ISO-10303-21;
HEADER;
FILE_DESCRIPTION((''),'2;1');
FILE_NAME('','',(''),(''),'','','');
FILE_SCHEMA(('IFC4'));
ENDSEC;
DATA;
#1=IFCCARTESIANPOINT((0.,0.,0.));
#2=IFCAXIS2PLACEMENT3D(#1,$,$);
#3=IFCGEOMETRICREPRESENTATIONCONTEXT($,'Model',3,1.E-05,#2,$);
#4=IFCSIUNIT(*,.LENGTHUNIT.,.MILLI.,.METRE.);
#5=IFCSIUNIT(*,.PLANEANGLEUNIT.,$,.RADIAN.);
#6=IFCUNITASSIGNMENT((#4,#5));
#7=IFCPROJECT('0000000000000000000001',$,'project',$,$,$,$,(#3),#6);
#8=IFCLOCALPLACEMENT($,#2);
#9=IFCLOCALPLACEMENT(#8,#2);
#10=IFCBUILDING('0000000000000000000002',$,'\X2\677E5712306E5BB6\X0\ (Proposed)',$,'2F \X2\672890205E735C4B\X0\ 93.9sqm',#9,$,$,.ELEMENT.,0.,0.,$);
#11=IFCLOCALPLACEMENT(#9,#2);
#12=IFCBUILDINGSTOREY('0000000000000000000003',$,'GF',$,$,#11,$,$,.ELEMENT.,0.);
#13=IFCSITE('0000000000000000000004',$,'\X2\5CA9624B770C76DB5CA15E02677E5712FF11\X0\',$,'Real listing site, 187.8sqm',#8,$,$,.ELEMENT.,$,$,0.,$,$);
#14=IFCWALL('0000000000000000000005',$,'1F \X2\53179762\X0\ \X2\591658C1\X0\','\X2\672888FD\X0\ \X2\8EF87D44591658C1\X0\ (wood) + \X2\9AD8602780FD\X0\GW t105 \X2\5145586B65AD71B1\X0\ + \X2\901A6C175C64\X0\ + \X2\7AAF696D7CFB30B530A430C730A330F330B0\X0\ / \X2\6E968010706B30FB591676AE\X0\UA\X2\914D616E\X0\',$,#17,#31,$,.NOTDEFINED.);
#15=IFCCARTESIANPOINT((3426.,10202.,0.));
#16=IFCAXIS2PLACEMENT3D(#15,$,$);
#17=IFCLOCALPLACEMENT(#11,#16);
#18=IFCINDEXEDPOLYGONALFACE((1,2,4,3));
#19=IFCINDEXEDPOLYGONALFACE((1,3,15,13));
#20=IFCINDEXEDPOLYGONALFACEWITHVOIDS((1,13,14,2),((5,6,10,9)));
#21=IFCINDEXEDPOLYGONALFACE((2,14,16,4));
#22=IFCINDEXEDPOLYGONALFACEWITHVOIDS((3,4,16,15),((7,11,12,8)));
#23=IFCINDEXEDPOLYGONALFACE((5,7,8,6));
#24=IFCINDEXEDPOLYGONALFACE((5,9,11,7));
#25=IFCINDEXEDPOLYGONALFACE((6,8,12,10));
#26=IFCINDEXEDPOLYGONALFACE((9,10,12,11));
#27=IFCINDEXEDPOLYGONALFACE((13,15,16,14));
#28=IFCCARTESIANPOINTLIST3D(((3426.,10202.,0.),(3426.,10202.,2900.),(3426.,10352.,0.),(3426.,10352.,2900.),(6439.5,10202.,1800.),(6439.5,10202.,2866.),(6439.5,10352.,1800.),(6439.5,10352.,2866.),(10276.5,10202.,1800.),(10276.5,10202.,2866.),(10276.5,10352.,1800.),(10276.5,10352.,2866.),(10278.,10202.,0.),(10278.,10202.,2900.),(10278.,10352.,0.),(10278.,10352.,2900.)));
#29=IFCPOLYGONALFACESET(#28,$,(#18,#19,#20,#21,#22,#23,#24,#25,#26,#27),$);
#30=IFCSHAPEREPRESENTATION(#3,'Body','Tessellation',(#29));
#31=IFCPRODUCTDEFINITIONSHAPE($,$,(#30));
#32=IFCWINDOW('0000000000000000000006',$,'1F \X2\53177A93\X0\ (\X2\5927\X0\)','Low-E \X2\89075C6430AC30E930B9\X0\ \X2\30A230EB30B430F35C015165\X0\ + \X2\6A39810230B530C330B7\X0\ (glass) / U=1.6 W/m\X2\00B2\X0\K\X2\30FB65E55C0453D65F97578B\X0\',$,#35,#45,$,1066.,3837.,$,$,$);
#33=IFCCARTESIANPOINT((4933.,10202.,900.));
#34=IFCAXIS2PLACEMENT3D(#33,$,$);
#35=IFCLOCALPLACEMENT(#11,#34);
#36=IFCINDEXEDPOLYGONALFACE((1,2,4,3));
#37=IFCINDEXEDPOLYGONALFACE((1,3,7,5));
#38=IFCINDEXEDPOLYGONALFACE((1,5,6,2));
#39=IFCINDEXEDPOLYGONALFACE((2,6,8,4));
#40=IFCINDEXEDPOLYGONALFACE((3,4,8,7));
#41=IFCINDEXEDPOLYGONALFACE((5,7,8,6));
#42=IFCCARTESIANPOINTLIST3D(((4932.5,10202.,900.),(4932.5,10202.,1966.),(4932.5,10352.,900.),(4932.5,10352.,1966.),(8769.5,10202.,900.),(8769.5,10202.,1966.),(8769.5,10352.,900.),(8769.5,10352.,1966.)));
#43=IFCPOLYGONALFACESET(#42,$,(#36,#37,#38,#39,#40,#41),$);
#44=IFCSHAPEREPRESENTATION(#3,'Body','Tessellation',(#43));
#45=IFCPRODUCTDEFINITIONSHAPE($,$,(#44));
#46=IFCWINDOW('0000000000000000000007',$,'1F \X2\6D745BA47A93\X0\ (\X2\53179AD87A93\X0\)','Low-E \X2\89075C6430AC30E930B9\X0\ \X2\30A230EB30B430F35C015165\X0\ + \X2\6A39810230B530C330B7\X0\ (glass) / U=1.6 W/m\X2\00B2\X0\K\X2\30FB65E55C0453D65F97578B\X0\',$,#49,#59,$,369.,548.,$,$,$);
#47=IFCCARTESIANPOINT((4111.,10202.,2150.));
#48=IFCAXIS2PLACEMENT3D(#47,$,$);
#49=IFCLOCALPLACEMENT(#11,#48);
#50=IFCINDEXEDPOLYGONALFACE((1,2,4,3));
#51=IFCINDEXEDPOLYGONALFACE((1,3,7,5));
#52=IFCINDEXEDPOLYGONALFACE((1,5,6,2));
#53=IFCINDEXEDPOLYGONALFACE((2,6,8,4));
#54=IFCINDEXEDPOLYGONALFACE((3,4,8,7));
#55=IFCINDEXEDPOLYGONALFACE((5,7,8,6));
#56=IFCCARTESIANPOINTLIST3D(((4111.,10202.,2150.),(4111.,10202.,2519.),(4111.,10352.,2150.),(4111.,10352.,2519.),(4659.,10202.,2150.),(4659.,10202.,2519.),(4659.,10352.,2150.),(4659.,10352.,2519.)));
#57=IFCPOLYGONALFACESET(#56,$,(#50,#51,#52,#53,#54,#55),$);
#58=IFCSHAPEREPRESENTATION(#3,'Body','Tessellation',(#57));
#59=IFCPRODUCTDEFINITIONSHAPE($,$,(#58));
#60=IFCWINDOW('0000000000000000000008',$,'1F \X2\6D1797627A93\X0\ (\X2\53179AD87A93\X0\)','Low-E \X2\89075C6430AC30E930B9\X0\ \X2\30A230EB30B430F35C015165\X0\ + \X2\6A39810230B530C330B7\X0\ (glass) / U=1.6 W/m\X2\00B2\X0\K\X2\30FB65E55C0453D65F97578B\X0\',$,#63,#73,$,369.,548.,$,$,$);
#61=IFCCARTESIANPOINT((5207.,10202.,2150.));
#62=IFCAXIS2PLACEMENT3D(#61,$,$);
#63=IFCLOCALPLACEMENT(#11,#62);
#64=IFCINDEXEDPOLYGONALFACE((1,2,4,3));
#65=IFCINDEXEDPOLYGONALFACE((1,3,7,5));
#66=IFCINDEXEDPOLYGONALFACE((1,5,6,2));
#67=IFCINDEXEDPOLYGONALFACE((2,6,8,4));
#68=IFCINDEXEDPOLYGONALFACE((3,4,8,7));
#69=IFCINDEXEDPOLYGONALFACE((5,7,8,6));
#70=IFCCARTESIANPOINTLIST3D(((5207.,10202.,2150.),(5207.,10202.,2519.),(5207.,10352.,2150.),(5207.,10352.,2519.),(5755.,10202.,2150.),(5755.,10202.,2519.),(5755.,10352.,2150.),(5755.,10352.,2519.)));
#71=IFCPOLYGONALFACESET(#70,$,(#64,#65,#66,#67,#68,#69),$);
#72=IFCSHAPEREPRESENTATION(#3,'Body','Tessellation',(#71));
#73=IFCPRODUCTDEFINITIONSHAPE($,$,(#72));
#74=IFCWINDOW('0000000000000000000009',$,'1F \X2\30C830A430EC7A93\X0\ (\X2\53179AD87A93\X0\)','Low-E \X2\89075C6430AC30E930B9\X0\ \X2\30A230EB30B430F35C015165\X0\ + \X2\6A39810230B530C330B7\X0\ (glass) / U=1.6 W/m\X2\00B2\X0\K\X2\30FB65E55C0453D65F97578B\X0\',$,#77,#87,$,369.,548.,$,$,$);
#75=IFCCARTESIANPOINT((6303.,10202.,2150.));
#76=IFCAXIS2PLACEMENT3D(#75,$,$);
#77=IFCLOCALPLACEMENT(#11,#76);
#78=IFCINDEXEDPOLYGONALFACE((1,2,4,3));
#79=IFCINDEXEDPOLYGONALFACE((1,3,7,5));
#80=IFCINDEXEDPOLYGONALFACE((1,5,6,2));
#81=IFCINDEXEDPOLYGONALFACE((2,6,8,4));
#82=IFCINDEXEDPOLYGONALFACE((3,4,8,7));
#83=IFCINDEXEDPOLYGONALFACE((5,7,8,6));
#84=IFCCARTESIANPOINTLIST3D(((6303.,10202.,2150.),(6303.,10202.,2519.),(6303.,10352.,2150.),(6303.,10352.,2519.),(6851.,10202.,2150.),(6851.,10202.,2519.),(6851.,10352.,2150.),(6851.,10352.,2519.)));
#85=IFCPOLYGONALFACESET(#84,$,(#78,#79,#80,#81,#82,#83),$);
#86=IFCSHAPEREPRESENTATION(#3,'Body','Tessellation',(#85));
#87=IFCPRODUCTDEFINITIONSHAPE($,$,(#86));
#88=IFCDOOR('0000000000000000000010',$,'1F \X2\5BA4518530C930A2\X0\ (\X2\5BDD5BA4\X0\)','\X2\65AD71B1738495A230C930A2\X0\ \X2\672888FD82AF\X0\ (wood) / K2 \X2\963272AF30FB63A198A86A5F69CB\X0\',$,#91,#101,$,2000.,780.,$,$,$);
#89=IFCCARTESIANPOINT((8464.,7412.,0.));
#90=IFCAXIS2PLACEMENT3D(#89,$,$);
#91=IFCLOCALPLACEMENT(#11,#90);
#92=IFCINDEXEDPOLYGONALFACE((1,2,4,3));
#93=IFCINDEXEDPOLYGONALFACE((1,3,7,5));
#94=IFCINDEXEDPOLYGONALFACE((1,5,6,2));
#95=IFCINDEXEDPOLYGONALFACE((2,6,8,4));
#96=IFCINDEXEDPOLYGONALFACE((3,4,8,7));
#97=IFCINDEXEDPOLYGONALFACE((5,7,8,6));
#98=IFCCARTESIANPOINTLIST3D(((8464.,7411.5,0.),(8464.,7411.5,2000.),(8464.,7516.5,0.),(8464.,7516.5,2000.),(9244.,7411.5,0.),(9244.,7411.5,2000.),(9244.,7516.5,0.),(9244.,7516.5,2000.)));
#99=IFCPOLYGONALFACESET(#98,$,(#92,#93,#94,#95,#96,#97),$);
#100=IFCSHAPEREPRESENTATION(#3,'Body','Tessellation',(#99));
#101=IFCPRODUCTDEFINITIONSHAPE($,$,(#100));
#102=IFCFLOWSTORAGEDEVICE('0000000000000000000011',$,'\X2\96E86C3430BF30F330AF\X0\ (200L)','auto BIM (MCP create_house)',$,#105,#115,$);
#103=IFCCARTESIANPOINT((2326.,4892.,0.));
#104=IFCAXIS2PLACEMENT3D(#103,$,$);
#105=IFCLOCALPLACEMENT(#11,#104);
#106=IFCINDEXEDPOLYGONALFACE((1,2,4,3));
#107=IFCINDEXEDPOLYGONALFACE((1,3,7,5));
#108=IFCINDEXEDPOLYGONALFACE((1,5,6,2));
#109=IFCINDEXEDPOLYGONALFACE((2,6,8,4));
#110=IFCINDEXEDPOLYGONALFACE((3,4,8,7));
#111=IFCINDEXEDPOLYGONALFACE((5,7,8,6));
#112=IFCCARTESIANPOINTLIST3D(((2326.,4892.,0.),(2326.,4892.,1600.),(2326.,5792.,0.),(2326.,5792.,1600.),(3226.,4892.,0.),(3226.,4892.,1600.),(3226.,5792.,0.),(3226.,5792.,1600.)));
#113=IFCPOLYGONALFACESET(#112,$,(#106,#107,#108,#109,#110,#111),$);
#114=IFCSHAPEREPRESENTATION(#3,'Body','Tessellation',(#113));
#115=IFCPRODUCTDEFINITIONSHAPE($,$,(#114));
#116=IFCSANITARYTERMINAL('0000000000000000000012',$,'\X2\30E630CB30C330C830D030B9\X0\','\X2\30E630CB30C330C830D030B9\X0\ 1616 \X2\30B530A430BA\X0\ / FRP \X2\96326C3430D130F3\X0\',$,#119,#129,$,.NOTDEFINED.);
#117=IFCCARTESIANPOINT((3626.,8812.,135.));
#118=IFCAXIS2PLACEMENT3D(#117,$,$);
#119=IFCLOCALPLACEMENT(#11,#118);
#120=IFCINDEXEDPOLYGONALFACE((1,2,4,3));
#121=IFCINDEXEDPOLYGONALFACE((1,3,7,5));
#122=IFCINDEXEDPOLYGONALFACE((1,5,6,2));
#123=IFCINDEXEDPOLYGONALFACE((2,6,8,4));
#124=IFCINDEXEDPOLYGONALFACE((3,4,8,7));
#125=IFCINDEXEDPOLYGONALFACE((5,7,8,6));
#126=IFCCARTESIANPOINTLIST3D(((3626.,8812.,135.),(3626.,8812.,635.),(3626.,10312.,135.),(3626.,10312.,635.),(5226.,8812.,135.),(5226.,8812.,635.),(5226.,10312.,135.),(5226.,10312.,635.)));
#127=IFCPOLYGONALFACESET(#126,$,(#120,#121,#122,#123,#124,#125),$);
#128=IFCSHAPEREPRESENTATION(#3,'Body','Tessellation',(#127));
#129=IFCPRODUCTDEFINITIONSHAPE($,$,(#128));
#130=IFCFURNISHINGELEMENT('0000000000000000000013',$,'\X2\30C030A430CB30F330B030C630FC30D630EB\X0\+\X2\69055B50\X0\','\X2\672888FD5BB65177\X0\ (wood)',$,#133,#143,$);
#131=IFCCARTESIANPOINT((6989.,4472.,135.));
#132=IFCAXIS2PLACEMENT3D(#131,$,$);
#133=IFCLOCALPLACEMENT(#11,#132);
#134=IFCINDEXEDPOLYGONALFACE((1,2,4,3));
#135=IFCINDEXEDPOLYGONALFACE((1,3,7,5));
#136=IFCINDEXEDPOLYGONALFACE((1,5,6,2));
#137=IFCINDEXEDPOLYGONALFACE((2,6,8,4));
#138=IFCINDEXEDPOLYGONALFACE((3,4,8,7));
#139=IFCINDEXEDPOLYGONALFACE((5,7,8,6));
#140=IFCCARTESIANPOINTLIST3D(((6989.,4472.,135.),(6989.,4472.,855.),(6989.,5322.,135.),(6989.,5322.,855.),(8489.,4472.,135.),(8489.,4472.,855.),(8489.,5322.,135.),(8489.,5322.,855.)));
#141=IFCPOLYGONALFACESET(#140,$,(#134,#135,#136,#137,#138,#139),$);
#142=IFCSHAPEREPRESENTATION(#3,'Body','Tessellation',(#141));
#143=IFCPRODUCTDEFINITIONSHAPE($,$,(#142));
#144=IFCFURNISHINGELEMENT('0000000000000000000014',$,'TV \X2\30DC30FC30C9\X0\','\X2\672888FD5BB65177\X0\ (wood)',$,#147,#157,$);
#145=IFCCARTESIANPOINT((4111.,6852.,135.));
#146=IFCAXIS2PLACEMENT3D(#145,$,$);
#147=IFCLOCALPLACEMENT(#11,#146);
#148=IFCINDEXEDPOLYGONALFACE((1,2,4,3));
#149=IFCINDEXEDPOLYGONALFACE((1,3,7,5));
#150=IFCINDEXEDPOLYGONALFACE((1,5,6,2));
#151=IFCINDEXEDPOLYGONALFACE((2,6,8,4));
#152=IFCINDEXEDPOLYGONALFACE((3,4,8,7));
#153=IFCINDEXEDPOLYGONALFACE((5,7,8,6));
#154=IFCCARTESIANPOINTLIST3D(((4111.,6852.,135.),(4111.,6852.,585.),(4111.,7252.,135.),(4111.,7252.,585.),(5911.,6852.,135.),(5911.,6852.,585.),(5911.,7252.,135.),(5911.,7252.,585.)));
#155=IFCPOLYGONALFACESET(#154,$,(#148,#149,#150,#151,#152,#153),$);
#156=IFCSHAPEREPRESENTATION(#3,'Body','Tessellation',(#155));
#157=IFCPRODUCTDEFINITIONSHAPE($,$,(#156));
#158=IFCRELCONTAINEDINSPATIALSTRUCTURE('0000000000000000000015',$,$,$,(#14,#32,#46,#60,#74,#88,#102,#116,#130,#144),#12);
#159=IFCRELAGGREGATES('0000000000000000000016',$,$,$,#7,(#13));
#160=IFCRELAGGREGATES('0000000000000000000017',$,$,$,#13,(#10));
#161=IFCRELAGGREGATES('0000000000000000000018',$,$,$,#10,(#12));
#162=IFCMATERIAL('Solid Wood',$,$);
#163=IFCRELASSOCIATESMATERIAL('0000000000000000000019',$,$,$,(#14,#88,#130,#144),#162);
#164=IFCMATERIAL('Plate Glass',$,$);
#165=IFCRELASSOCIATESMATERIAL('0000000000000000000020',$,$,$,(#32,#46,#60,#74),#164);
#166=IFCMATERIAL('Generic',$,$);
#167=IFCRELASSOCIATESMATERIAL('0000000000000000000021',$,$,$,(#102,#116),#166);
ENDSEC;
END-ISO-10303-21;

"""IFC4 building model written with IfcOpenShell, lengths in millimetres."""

from ifc_helpers import new_model, si_unit, frame, frame_2d, origin, place, context, project, spatial, rectangle, extrude, material, element, fill, save


model = new_model("IFC4")

# Units and contexts
model_context = context("Model", 3, precision=1e-05, world=origin())
ifc_project = project(units=[si_unit("LENGTHUNIT", "METRE", prefix="MILLI"), si_unit("PLANEANGLEUNIT", "RADIAN")], contexts=[model_context])

# Site, building, storey
site_placement = place(None, origin())
site = spatial("IfcSite", under=ifc_project, at=site_placement, Name="岩手県盛岡市松園１", ObjectType="Real listing site, 187.8sqm", CompositionType="ELEMENT", RefElevation=0.0)
building_placement = place(site_placement, origin())
building = spatial("IfcBuilding", under=site, at=building_placement, Name="松園の家 (Proposed)", ObjectType="2F 木造平屋 93.9sqm", CompositionType="ELEMENT", ElevationOfRefHeight=0.0, ElevationOfTerrain=0.0)
storey_placement = place(building_placement, origin())
storey = spatial("IfcBuildingStorey", under=building, at=storey_placement, Name="GF", CompositionType="ELEMENT", Elevation=0.0)

# Wall, openings, windows
ifc_material_1 = material(Name="Solid Wood")
wall_1_placement = place(storey_placement, frame((3426.0, 10202.0, 0.0)))
wall_1 = element("IfcWall", 1, at=wall_1_placement, inside=storey, material=ifc_material_1, Name="1F 北面 外壁", Description="木製 軸組外壁 (wood) + 高性能GW t105 充填断熱 + 通気層 + 窯業系サイディング / 準耐火・外皮UA配慮", PredefinedType="NOTDEFINED", context=model_context, shape_type="SweptSolid", body=[
    extrude(rectangle(XDim=6852.0, YDim=150.0, at=frame_2d((3426.0, 75.0))), frame((3426.0, 10202.0, 0.0)), (0.0, 0.0, 1.0), 2900.0),
])
opening_1_placement = place(storey_placement, frame((4933.0, 10202.0, 900.0)))
opening_1 = element("IfcOpeningElement", 2, at=opening_1_placement, cuts=wall_1, PredefinedType="NOTDEFINED", context=model_context, shape_type="SweptSolid", body=[
    extrude(rectangle(XDim=3837.0, YDim=150.0, at=frame_2d((1918.0, 75.0))), frame((4933.0, 10202.0, 900.0)), (0.0, 0.0, 1.0), 1066.0),
])
opening_2_placement = place(storey_placement, frame((4111.0, 10202.0, 2150.0)))
opening_2 = element("IfcOpeningElement", 3, at=opening_2_placement, cuts=wall_1, PredefinedType="NOTDEFINED", context=model_context, shape_type="SweptSolid", body=[
    extrude(rectangle(XDim=548.0, YDim=150.0, at=frame_2d((274.0, 75.0))), frame((4111.0, 10202.0, 2150.0)), (0.0, 0.0, 1.0), 369.0),
])
opening_3_placement = place(storey_placement, frame((5207.0, 10202.0, 2150.0)))
opening_3 = element("IfcOpeningElement", 4, at=opening_3_placement, cuts=wall_1, PredefinedType="NOTDEFINED", context=model_context, shape_type="SweptSolid", body=[
    extrude(rectangle(XDim=548.0, YDim=150.0, at=frame_2d((274.0, 75.0))), frame((5207.0, 10202.0, 2150.0)), (0.0, 0.0, 1.0), 369.0),
])
opening_4_placement = place(storey_placement, frame((6303.0, 10202.0, 2150.0)))
opening_4 = element("IfcOpeningElement", 5, at=opening_4_placement, cuts=wall_1, PredefinedType="NOTDEFINED", context=model_context, shape_type="SweptSolid", body=[
    extrude(rectangle(XDim=548.0, YDim=150.0, at=frame_2d((274.0, 75.0))), frame((6303.0, 10202.0, 2150.0)), (0.0, 0.0, 1.0), 369.0),
])
ifc_material_2 = material(Name="Plate Glass")
window_1_placement = place(storey_placement, frame((4933.0, 10202.0, 900.0)))
window_1 = element("IfcWindow", 6, at=window_1_placement, inside=storey, material=ifc_material_2, Name="1F 北窓 (大)", Description="Low-E 複層ガラス アルゴン封入 + 樹脂サッシ (glass) / U=1.6 W/m²K・日射取得型", OverallHeight=1066.0, OverallWidth=3837.0, context=model_context, shape_type="SweptSolid", body=[
    extrude(rectangle(XDim=3837.0, YDim=150.0, at=frame_2d((1918.0, 75.0))), frame((4933.0, 10202.0, 900.0)), (0.0, 0.0, 1.0), 1066.0),
])
fill(opening_1, window_1)
window_2_placement = place(storey_placement, frame((4111.0, 10202.0, 2150.0)))
window_2 = element("IfcWindow", 7, at=window_2_placement, inside=storey, material=ifc_material_2, Name="1F 浴室窓 (北高窓)", Description="Low-E 複層ガラス アルゴン封入 + 樹脂サッシ (glass) / U=1.6 W/m²K・日射取得型", OverallHeight=369.0, OverallWidth=548.0, context=model_context, shape_type="SweptSolid", body=[
    extrude(rectangle(XDim=548.0, YDim=150.0, at=frame_2d((274.0, 75.0))), frame((4111.0, 10202.0, 2150.0)), (0.0, 0.0, 1.0), 369.0),
])
fill(opening_2, window_2)
window_3_placement = place(storey_placement, frame((5207.0, 10202.0, 2150.0)))
window_3 = element("IfcWindow", 8, at=window_3_placement, inside=storey, material=ifc_material_2, Name="1F 洗面窓 (北高窓)", Description="Low-E 複層ガラス アルゴン封入 + 樹脂サッシ (glass) / U=1.6 W/m²K・日射取得型", OverallHeight=369.0, OverallWidth=548.0, context=model_context, shape_type="SweptSolid", body=[
    extrude(rectangle(XDim=548.0, YDim=150.0, at=frame_2d((274.0, 75.0))), frame((5207.0, 10202.0, 2150.0)), (0.0, 0.0, 1.0), 369.0),
])
fill(opening_3, window_3)
window_4_placement = place(storey_placement, frame((6303.0, 10202.0, 2150.0)))
window_4 = element("IfcWindow", 9, at=window_4_placement, inside=storey, material=ifc_material_2, Name="1F トイレ窓 (北高窓)", Description="Low-E 複層ガラス アルゴン封入 + 樹脂サッシ (glass) / U=1.6 W/m²K・日射取得型", OverallHeight=369.0, OverallWidth=548.0, context=model_context, shape_type="SweptSolid", body=[
    extrude(rectangle(XDim=548.0, YDim=150.0, at=frame_2d((274.0, 75.0))), frame((6303.0, 10202.0, 2150.0)), (0.0, 0.0, 1.0), 369.0),
])
fill(opening_4, window_4)

# Door
door_1_placement = place(storey_placement, frame((8464.0, 7412.0, 0.0)))
element("IfcDoor", 10, at=door_1_placement, inside=storey, material=ifc_material_1, Name="1F 室内ドア (寝室)", Description="断熱玄関ドア 木製芯 (wood) / K2 防犯・採風機構", OverallHeight=2000.0, OverallWidth=780.0, context=model_context, shape_type="SweptSolid", body=[
    extrude(rectangle(XDim=780.0, YDim=105.0, at=frame_2d((390.0, 52.0))), frame((8464.0, 7412.0, 0.0)), (0.0, 0.0, 1.0), 2000.0),
])

# Flow storage device
ifc_material_3 = material(Name="Generic")
flow_storage_device_placement = place(storey_placement, frame((2326.0, 4892.0, 0.0)))
element("IfcFlowStorageDevice", 11, at=flow_storage_device_placement, inside=storey, material=ifc_material_3, Name="雨水タンク (200L)", Description="auto BIM (MCP create_house)", context=model_context, shape_type="SweptSolid", body=[
    extrude(rectangle(XDim=900.0, YDim=900.0, at=frame_2d((450.0, 450.0))), frame((2326.0, 4892.0, 0.0)), (0.0, 0.0, 1.0), 1600.0),
])

# Sanitary terminal
sanitary_terminal_placement = place(storey_placement, frame((3626.0, 8812.0, 135.0)))
element("IfcSanitaryTerminal", 12, at=sanitary_terminal_placement, inside=storey, material=ifc_material_3, Name="ユニットバス", Description="ユニットバス 1616 サイズ / FRP 防水パン", PredefinedType="NOTDEFINED", context=model_context, shape_type="SweptSolid", body=[
    extrude(rectangle(XDim=1600.0, YDim=1500.0, at=frame_2d((800.0, 750.0))), frame((3626.0, 8812.0, 135.0)), (0.0, 0.0, 1.0), 500.0),
])

# Furnishing elements
furnishing_1_placement = place(storey_placement, frame((6989.0, 4472.0, 135.0)))
element("IfcFurnishingElement", 13, at=furnishing_1_placement, inside=storey, material=ifc_material_1, Name="ダイニングテーブル+椅子", Description="木製家具 (wood)", context=model_context, shape_type="SweptSolid", body=[
    extrude(rectangle(XDim=1500.0, YDim=850.0, at=frame_2d((750.0, 425.0))), frame((6989.0, 4472.0, 135.0)), (0.0, 0.0, 1.0), 720.0),
])
furnishing_2_placement = place(storey_placement, frame((4111.0, 6852.0, 135.0)))
element("IfcFurnishingElement", 14, at=furnishing_2_placement, inside=storey, material=ifc_material_1, Name="TV ボード", Description="木製家具 (wood)", context=model_context, shape_type="SweptSolid", body=[
    extrude(rectangle(XDim=1800.0, YDim=400.0, at=frame_2d((900.0, 200.0))), frame((4111.0, 6852.0, 135.0)), (0.0, 0.0, 1.0), 450.0),
])

save(model, "model.ifc")
